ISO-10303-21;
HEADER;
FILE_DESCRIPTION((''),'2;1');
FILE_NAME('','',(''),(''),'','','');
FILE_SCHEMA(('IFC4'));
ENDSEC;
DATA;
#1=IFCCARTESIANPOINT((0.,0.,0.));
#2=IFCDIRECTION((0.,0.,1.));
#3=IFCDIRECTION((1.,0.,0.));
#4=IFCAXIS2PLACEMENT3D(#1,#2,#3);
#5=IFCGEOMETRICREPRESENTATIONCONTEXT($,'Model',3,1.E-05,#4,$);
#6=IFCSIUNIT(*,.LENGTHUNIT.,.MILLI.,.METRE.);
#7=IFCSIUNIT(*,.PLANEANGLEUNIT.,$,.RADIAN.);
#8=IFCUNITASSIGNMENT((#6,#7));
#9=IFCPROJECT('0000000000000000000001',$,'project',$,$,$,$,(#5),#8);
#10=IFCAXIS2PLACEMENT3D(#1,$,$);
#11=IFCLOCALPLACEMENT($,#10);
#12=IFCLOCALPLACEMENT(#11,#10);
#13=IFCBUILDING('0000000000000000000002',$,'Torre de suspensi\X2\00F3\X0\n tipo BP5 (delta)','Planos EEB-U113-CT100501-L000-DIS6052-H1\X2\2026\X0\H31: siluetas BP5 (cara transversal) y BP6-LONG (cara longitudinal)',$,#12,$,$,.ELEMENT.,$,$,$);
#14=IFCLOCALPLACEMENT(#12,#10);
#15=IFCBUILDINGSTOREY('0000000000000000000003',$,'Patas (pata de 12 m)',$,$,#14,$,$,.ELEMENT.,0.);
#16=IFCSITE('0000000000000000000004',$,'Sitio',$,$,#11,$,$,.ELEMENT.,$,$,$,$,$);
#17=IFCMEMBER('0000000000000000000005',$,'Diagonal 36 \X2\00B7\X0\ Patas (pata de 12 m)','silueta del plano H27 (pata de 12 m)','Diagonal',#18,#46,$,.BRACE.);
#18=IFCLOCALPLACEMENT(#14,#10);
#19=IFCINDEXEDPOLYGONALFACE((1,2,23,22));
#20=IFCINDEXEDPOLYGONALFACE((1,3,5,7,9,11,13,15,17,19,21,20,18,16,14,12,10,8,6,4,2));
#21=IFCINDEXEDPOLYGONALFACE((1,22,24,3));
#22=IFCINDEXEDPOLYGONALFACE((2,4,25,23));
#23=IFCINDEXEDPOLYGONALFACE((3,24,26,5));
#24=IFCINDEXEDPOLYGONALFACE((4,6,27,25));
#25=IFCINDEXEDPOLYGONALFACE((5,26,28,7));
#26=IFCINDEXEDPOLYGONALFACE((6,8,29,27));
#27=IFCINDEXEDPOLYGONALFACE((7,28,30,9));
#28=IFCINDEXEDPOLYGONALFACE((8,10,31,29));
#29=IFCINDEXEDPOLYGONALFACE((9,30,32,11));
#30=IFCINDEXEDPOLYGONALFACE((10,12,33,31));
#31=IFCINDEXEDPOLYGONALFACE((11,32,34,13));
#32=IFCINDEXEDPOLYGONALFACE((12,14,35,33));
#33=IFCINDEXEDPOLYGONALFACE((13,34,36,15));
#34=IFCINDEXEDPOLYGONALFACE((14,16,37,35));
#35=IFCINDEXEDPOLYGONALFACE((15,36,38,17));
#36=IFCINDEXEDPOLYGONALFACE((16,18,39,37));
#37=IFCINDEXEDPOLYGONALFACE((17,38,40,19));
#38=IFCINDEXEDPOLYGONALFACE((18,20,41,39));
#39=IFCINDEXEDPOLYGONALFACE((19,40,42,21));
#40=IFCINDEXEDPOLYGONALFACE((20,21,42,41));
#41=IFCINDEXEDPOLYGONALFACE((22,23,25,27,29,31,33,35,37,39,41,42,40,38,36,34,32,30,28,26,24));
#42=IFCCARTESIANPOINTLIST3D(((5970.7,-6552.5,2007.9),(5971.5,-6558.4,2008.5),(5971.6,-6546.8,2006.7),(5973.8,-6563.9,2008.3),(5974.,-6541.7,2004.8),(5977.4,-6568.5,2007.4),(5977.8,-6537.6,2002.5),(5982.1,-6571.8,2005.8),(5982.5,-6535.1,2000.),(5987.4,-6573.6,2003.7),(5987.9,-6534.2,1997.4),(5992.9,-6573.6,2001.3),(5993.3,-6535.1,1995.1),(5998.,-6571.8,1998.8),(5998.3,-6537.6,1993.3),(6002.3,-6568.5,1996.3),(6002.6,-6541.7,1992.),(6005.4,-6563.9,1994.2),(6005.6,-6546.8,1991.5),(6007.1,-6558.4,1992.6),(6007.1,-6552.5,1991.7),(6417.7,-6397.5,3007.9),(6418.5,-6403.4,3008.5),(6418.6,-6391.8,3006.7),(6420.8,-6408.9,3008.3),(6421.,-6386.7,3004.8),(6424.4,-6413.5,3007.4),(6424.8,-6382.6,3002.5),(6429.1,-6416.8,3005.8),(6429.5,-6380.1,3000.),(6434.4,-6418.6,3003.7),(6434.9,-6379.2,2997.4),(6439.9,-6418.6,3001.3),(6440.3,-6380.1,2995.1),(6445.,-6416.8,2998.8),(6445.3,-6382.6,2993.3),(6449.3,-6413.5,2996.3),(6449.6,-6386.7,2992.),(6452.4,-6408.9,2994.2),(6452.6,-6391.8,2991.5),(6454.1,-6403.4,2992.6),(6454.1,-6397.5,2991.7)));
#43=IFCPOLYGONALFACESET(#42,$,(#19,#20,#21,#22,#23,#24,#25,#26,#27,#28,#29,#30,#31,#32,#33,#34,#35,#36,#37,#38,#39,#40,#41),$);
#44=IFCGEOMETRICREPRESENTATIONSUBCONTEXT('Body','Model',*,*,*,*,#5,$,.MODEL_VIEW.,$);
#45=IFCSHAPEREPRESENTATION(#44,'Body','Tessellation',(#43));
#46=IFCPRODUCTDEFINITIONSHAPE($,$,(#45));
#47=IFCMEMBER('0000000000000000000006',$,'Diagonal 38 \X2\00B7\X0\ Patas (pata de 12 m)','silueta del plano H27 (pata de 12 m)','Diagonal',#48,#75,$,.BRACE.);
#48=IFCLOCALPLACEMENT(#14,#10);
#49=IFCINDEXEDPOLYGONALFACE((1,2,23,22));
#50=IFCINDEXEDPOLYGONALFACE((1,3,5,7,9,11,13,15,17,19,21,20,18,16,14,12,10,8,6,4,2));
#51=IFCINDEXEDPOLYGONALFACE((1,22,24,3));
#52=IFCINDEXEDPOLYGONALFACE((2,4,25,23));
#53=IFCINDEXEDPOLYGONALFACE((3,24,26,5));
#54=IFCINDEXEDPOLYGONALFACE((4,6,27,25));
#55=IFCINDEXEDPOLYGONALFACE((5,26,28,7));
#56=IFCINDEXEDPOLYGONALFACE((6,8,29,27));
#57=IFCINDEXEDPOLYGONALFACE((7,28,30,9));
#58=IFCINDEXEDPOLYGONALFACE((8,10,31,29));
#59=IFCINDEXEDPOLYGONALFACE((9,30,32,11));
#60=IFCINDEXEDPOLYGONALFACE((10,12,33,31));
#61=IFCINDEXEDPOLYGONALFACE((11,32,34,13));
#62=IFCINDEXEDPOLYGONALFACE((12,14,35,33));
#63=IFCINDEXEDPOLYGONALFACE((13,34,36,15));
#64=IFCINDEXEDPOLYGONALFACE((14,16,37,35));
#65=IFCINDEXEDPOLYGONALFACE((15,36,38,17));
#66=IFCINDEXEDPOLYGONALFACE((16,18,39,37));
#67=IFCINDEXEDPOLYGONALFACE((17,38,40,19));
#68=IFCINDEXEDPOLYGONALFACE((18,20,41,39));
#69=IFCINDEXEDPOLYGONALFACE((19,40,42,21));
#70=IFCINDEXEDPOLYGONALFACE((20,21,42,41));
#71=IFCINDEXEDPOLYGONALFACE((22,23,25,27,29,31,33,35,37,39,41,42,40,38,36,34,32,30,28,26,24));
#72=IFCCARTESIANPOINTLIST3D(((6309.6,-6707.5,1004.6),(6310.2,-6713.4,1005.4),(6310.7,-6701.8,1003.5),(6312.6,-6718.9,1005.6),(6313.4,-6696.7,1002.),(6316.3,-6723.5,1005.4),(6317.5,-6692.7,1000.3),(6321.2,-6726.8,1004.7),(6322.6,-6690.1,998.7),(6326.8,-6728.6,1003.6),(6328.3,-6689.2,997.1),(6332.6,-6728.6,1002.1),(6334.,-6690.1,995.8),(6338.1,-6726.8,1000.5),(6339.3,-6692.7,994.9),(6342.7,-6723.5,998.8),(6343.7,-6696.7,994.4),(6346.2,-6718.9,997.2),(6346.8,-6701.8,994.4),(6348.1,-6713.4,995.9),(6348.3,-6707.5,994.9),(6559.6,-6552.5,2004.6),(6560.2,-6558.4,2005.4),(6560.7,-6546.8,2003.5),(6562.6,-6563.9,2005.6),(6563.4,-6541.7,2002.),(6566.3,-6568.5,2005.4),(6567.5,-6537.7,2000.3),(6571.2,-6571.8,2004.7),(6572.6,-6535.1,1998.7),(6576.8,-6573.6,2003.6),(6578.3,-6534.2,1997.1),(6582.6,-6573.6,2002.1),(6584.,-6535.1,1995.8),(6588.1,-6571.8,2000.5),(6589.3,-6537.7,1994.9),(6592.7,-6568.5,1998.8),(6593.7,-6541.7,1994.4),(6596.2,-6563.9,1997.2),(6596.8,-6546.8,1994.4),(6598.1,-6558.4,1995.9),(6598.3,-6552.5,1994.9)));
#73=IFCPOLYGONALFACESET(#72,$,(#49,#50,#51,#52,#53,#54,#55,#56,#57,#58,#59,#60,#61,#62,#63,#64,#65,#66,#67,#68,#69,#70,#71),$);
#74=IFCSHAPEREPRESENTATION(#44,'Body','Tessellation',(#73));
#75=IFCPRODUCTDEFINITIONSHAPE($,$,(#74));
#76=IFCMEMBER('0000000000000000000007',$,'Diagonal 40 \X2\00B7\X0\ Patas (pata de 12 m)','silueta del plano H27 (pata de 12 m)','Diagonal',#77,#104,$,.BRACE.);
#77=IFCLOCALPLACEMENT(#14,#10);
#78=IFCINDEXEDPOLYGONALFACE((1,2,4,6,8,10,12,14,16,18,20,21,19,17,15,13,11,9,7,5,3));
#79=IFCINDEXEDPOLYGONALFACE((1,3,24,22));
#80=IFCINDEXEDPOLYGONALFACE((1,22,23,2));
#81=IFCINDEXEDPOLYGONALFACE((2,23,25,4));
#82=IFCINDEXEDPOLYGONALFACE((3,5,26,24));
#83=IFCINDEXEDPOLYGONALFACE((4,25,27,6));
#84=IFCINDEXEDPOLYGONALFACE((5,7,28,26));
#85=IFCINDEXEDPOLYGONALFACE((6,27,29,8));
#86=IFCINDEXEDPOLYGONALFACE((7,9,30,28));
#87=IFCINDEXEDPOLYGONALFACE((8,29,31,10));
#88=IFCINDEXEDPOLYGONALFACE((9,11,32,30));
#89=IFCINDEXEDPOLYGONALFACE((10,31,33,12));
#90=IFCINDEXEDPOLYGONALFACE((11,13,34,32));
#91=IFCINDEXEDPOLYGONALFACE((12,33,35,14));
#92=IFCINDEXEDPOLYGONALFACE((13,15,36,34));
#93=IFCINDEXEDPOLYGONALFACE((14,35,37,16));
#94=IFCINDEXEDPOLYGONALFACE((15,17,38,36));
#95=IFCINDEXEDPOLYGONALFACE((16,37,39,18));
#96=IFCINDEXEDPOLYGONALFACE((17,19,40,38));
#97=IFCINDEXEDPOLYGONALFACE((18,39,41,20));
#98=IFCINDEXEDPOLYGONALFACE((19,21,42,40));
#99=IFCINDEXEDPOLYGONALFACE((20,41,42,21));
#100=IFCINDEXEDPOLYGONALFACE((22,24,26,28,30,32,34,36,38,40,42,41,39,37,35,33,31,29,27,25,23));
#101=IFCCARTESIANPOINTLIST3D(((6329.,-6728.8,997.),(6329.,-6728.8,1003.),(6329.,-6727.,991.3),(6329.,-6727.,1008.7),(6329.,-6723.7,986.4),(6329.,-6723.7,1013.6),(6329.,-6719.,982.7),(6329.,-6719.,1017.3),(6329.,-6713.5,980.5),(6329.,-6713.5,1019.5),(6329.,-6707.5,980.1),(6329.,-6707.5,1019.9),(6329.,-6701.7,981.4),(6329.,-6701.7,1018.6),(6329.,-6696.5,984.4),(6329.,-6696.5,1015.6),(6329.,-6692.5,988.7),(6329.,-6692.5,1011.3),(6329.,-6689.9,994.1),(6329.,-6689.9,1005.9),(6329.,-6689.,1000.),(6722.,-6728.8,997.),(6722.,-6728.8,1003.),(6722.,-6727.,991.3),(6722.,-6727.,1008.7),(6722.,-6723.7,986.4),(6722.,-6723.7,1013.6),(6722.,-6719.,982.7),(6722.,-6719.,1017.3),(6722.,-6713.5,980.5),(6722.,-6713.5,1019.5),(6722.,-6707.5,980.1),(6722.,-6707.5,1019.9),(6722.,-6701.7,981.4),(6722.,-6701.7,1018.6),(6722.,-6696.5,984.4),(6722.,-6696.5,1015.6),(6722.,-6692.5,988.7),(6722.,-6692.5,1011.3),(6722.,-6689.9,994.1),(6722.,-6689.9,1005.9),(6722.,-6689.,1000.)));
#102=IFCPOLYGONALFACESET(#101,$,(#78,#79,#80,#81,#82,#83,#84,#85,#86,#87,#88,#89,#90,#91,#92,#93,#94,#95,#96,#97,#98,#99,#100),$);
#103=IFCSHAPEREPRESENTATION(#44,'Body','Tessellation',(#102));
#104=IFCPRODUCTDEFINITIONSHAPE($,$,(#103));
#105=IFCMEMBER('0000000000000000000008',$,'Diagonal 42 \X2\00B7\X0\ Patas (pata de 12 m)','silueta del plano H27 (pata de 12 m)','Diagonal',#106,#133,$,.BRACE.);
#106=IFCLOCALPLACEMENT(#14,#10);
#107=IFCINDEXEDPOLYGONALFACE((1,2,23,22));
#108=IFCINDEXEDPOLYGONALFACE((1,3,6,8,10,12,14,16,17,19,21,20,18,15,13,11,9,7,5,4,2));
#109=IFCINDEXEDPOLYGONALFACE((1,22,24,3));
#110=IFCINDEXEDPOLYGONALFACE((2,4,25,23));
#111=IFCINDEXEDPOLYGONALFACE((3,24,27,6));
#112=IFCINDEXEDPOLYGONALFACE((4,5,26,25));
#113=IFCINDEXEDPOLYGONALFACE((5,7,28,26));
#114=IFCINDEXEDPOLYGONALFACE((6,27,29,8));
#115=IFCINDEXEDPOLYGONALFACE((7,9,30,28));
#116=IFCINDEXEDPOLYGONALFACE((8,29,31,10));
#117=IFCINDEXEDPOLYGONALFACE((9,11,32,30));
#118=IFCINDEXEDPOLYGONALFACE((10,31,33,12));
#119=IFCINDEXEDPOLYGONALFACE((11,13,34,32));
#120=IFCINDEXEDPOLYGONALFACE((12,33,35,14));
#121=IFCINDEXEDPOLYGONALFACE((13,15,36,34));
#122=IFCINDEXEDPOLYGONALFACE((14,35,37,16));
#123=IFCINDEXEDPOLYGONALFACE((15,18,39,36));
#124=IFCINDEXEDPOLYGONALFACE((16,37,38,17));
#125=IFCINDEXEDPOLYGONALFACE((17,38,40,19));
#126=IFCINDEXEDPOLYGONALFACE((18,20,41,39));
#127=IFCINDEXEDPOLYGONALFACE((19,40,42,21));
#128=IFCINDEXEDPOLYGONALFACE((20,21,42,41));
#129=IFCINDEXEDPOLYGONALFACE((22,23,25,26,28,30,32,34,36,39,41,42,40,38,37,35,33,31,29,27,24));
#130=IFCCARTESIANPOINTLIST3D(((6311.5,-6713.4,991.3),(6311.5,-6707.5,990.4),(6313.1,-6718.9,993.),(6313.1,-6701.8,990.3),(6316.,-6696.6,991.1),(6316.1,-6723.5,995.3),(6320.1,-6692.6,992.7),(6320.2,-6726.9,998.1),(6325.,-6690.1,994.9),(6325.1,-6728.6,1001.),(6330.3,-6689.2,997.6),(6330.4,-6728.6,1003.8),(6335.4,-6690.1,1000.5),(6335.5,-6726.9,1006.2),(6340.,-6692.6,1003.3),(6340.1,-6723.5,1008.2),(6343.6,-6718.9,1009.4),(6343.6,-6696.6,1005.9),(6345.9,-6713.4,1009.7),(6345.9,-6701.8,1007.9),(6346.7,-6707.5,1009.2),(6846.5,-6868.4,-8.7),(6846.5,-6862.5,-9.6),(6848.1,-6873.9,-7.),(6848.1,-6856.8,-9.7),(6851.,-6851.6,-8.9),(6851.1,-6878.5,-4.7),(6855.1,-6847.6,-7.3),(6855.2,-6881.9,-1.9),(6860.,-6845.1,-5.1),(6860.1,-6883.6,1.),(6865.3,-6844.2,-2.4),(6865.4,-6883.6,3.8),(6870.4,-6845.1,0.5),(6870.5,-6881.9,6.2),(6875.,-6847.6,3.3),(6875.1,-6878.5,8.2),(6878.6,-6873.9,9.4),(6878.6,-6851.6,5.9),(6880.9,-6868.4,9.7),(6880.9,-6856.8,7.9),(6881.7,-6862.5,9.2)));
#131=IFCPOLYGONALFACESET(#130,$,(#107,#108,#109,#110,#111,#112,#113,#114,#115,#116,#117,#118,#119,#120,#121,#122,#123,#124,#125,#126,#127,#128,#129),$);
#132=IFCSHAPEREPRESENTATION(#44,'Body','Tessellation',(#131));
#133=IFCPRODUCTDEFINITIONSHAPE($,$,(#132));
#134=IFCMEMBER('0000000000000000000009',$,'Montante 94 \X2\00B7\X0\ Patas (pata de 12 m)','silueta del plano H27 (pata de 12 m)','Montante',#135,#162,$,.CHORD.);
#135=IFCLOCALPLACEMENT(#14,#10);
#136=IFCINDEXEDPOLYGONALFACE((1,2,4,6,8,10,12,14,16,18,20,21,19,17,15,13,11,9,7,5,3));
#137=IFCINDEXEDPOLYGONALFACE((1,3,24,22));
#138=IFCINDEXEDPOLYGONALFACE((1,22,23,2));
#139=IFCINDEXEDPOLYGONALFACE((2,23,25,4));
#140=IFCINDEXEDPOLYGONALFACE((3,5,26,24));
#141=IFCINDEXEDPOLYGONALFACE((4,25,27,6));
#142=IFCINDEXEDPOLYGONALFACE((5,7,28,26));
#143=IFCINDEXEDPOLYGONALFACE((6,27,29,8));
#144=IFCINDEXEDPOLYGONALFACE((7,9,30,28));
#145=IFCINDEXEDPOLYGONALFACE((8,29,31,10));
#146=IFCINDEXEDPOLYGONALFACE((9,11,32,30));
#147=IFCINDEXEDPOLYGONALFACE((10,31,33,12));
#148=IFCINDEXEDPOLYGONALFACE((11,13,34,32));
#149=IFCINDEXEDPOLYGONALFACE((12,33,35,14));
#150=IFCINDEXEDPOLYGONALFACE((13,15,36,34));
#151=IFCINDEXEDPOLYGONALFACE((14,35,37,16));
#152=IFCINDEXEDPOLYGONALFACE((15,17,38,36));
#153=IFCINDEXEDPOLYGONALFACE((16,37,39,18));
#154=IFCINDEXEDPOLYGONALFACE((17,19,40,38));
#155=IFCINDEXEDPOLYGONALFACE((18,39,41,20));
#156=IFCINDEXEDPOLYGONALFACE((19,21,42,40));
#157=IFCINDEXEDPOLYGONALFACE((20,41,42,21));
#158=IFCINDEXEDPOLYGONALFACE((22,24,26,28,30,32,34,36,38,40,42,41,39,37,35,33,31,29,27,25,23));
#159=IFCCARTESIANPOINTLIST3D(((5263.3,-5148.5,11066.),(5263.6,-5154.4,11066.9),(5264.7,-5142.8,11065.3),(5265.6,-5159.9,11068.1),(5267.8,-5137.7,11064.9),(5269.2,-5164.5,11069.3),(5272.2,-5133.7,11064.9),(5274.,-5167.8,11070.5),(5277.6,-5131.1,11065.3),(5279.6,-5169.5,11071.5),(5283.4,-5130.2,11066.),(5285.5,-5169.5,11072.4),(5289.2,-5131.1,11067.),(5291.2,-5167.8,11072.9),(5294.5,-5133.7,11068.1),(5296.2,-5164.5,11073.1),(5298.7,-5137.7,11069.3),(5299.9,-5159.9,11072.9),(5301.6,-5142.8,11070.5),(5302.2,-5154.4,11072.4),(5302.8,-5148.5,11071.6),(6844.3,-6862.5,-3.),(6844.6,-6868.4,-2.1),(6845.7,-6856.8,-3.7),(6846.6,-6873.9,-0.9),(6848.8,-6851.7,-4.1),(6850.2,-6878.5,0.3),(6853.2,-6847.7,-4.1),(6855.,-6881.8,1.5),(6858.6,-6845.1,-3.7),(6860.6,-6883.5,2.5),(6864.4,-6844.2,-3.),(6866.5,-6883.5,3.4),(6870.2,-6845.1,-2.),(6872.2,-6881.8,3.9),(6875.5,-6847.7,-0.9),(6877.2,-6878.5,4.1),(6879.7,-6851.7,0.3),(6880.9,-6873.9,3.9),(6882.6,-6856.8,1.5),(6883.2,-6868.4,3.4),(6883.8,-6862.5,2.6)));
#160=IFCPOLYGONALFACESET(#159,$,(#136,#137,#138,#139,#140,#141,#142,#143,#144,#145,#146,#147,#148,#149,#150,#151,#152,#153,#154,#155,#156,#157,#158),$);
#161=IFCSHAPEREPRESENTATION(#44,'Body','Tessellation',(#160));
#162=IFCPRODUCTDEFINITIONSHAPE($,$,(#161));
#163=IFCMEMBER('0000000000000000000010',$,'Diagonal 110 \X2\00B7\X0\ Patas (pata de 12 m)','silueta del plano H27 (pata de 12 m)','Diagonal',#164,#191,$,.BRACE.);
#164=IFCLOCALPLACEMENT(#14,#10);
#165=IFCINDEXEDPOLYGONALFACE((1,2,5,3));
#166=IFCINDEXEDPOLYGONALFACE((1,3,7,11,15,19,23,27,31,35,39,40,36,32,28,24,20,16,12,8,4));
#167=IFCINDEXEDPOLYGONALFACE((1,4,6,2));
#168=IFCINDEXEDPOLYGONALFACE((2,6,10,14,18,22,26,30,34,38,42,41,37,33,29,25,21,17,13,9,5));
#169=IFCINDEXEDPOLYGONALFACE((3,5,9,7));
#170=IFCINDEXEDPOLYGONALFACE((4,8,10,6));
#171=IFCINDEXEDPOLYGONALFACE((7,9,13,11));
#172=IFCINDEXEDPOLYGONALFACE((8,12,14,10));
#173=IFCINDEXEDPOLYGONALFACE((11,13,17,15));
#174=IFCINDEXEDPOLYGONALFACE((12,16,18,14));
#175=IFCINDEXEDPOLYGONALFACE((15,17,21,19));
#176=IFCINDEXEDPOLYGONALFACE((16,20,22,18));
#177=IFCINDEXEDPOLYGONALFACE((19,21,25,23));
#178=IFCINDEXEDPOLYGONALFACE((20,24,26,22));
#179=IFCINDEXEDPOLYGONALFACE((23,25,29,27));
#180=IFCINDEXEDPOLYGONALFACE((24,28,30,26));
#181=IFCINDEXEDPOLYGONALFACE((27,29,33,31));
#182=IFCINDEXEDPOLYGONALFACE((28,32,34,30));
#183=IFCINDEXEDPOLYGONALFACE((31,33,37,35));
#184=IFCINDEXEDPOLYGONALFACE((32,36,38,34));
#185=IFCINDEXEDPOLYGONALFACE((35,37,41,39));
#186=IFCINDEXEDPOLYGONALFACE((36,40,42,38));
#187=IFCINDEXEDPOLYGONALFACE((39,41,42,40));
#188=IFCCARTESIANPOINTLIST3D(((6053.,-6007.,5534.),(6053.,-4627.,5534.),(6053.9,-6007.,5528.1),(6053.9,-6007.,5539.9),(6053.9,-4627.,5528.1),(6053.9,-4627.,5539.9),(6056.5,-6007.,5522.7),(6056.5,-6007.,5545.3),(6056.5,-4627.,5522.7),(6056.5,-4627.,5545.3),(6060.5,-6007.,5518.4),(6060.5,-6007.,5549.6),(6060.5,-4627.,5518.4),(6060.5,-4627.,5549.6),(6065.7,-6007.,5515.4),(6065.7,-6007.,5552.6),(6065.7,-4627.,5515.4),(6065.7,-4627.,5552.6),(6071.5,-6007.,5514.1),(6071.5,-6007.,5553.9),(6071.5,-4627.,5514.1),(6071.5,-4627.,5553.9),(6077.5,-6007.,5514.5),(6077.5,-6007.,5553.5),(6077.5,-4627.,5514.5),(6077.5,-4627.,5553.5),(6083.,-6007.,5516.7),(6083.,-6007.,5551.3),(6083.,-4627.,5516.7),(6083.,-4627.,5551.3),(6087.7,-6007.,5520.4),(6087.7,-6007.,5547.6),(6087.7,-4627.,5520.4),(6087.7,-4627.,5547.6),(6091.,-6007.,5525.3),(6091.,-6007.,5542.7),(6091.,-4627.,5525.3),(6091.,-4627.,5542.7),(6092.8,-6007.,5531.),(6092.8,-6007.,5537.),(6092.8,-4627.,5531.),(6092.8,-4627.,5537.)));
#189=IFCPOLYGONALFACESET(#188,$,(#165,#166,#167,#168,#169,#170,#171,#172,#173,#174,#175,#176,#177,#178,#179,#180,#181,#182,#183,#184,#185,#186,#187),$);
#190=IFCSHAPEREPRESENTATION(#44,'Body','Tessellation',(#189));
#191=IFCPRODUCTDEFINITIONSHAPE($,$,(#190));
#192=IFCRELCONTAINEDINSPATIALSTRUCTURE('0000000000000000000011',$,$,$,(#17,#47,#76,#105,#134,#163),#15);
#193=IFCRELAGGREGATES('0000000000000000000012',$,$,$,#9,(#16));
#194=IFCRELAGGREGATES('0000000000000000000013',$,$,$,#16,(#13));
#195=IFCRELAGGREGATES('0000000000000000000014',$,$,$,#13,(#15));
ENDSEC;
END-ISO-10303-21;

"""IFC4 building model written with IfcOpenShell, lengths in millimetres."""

from ifc_helpers import new_model, si_unit, frame, origin, origin_with_axes, place, context, subcontext, project, spatial, circle, extrude, element, save


model = new_model("IFC4")

# Units and contexts
model_context = context("Model", 3, precision=1e-05, world=origin_with_axes())
body_context = subcontext(model_context, "Body", "Model", "MODEL_VIEW")
ifc_project = project(units=[si_unit("LENGTHUNIT", "METRE", prefix="MILLI"), si_unit("PLANEANGLEUNIT", "RADIAN")], contexts=[model_context])

# Site, building, storey
site_placement = place(None, origin())
site = spatial("IfcSite", under=ifc_project, at=site_placement, Name="Sitio", CompositionType="ELEMENT")
building_placement = place(site_placement, origin())
building = spatial("IfcBuilding", under=site, at=building_placement, Name="Torre de suspensión tipo BP5 (delta)", Description="Planos EEB-U113-CT100501-L000-DIS6052-H1…H31: siluetas BP5 (cara transversal) y BP6-LONG (cara longitudinal)", CompositionType="ELEMENT")
storey_placement = place(building_placement, origin())
storey = spatial("IfcBuildingStorey", under=building, at=storey_placement, Name="Patas (pata de 12 m)", CompositionType="ELEMENT", Elevation=0.0)

# Members
member_1_placement = place(storey_placement, frame((5989.0, -6554.0, 2000.0), z_axis=(0.40406, 0.14011, 0.903938), x_axis=(-0.057177, 0.990136, -0.127913)))
element("IfcMember", 1, at=member_1_placement, inside=storey, Name="Diagonal 36 · Patas (pata de 12 m)", Description="silueta del plano H27 (pata de 12 m)", ObjectType="Diagonal", PredefinedType="BRACE", context=body_context, shape_type="SweptSolid", body=[
    extrude(circle(Radius=20.0), None, (0.0, 0.0, 1.0), 1106.3),
])
member_2_placement = place(storey_placement, frame((6329.0, -6709.0, 1000.0), z_axis=(0.239839, 0.1487, 0.959357), x_axis=(-0.036065, 0.988882, -0.14426)))
element("IfcMember", 2, at=member_2_placement, inside=storey, Name="Diagonal 38 · Patas (pata de 12 m)", Description="silueta del plano H27 (pata de 12 m)", ObjectType="Diagonal", PredefinedType="BRACE", context=body_context, shape_type="SweptSolid", body=[
    extrude(circle(Radius=20.0), None, (0.0, 0.0, 1.0), 1042.4),
])
member_3_placement = place(storey_placement, frame((6722.0, -6709.0, 1000.0), z_axis=(-1.0, 0.0, 0.0), x_axis=(0.0, 1.0, 0.0)))
element("IfcMember", 3, at=member_3_placement, inside=storey, Name="Diagonal 40 · Patas (pata de 12 m)", Description="silueta del plano H27 (pata de 12 m)", ObjectType="Diagonal", PredefinedType="BRACE", context=body_context, shape_type="SweptSolid", body=[
    extrude(circle(Radius=20.0), None, (0.0, 0.0, 1.0), 393.0),
])
member_4_placement = place(storey_placement, frame((6864.0, -6864.0, 0.0), z_axis=(-0.467387, 0.135411, 0.873621), x_axis=(0.063878, 0.990789, -0.119398)))
element("IfcMember", 4, at=member_4_placement, inside=storey, Name="Diagonal 42 · Patas (pata de 12 m)", Description="silueta del plano H27 (pata de 12 m)", ObjectType="Diagonal", PredefinedType="BRACE", context=body_context, shape_type="SweptSolid", body=[
    extrude(circle(Radius=20.0), None, (0.0, 0.0, 1.0), 1144.7),
])
member_5_placement = place(storey_placement, frame((6864.0, -6864.0, 0.0), z_axis=(-0.139764, 0.151521, 0.978523), x_axis=(0.021425, 0.988454, -0.149999)))
element("IfcMember", 5, at=member_5_placement, inside=storey, Name="Montante 94 · Patas (pata de 12 m)", Description="silueta del plano H27 (pata de 12 m)", ObjectType="Montante", PredefinedType="CHORD", context=body_context, shape_type="SweptSolid", body=[
    extrude(circle(Radius=20.0), None, (0.0, 0.0, 1.0), 11311.9),
])
member_6_placement = place(storey_placement, frame((6073.0, -6007.0, 5534.0), z_axis=(0.0, 1.0, 0.0), x_axis=(-1.0, 0.0, 0.0)))
element("IfcMember", 6, at=member_6_placement, inside=storey, Name="Diagonal 110 · Patas (pata de 12 m)", Description="silueta del plano H27 (pata de 12 m)", ObjectType="Diagonal", PredefinedType="BRACE", context=body_context, shape_type="SweptSolid", body=[
    extrude(circle(Radius=20.0), None, (0.0, 0.0, 1.0), 1380.0),
])

save(model, "model.ifc")
